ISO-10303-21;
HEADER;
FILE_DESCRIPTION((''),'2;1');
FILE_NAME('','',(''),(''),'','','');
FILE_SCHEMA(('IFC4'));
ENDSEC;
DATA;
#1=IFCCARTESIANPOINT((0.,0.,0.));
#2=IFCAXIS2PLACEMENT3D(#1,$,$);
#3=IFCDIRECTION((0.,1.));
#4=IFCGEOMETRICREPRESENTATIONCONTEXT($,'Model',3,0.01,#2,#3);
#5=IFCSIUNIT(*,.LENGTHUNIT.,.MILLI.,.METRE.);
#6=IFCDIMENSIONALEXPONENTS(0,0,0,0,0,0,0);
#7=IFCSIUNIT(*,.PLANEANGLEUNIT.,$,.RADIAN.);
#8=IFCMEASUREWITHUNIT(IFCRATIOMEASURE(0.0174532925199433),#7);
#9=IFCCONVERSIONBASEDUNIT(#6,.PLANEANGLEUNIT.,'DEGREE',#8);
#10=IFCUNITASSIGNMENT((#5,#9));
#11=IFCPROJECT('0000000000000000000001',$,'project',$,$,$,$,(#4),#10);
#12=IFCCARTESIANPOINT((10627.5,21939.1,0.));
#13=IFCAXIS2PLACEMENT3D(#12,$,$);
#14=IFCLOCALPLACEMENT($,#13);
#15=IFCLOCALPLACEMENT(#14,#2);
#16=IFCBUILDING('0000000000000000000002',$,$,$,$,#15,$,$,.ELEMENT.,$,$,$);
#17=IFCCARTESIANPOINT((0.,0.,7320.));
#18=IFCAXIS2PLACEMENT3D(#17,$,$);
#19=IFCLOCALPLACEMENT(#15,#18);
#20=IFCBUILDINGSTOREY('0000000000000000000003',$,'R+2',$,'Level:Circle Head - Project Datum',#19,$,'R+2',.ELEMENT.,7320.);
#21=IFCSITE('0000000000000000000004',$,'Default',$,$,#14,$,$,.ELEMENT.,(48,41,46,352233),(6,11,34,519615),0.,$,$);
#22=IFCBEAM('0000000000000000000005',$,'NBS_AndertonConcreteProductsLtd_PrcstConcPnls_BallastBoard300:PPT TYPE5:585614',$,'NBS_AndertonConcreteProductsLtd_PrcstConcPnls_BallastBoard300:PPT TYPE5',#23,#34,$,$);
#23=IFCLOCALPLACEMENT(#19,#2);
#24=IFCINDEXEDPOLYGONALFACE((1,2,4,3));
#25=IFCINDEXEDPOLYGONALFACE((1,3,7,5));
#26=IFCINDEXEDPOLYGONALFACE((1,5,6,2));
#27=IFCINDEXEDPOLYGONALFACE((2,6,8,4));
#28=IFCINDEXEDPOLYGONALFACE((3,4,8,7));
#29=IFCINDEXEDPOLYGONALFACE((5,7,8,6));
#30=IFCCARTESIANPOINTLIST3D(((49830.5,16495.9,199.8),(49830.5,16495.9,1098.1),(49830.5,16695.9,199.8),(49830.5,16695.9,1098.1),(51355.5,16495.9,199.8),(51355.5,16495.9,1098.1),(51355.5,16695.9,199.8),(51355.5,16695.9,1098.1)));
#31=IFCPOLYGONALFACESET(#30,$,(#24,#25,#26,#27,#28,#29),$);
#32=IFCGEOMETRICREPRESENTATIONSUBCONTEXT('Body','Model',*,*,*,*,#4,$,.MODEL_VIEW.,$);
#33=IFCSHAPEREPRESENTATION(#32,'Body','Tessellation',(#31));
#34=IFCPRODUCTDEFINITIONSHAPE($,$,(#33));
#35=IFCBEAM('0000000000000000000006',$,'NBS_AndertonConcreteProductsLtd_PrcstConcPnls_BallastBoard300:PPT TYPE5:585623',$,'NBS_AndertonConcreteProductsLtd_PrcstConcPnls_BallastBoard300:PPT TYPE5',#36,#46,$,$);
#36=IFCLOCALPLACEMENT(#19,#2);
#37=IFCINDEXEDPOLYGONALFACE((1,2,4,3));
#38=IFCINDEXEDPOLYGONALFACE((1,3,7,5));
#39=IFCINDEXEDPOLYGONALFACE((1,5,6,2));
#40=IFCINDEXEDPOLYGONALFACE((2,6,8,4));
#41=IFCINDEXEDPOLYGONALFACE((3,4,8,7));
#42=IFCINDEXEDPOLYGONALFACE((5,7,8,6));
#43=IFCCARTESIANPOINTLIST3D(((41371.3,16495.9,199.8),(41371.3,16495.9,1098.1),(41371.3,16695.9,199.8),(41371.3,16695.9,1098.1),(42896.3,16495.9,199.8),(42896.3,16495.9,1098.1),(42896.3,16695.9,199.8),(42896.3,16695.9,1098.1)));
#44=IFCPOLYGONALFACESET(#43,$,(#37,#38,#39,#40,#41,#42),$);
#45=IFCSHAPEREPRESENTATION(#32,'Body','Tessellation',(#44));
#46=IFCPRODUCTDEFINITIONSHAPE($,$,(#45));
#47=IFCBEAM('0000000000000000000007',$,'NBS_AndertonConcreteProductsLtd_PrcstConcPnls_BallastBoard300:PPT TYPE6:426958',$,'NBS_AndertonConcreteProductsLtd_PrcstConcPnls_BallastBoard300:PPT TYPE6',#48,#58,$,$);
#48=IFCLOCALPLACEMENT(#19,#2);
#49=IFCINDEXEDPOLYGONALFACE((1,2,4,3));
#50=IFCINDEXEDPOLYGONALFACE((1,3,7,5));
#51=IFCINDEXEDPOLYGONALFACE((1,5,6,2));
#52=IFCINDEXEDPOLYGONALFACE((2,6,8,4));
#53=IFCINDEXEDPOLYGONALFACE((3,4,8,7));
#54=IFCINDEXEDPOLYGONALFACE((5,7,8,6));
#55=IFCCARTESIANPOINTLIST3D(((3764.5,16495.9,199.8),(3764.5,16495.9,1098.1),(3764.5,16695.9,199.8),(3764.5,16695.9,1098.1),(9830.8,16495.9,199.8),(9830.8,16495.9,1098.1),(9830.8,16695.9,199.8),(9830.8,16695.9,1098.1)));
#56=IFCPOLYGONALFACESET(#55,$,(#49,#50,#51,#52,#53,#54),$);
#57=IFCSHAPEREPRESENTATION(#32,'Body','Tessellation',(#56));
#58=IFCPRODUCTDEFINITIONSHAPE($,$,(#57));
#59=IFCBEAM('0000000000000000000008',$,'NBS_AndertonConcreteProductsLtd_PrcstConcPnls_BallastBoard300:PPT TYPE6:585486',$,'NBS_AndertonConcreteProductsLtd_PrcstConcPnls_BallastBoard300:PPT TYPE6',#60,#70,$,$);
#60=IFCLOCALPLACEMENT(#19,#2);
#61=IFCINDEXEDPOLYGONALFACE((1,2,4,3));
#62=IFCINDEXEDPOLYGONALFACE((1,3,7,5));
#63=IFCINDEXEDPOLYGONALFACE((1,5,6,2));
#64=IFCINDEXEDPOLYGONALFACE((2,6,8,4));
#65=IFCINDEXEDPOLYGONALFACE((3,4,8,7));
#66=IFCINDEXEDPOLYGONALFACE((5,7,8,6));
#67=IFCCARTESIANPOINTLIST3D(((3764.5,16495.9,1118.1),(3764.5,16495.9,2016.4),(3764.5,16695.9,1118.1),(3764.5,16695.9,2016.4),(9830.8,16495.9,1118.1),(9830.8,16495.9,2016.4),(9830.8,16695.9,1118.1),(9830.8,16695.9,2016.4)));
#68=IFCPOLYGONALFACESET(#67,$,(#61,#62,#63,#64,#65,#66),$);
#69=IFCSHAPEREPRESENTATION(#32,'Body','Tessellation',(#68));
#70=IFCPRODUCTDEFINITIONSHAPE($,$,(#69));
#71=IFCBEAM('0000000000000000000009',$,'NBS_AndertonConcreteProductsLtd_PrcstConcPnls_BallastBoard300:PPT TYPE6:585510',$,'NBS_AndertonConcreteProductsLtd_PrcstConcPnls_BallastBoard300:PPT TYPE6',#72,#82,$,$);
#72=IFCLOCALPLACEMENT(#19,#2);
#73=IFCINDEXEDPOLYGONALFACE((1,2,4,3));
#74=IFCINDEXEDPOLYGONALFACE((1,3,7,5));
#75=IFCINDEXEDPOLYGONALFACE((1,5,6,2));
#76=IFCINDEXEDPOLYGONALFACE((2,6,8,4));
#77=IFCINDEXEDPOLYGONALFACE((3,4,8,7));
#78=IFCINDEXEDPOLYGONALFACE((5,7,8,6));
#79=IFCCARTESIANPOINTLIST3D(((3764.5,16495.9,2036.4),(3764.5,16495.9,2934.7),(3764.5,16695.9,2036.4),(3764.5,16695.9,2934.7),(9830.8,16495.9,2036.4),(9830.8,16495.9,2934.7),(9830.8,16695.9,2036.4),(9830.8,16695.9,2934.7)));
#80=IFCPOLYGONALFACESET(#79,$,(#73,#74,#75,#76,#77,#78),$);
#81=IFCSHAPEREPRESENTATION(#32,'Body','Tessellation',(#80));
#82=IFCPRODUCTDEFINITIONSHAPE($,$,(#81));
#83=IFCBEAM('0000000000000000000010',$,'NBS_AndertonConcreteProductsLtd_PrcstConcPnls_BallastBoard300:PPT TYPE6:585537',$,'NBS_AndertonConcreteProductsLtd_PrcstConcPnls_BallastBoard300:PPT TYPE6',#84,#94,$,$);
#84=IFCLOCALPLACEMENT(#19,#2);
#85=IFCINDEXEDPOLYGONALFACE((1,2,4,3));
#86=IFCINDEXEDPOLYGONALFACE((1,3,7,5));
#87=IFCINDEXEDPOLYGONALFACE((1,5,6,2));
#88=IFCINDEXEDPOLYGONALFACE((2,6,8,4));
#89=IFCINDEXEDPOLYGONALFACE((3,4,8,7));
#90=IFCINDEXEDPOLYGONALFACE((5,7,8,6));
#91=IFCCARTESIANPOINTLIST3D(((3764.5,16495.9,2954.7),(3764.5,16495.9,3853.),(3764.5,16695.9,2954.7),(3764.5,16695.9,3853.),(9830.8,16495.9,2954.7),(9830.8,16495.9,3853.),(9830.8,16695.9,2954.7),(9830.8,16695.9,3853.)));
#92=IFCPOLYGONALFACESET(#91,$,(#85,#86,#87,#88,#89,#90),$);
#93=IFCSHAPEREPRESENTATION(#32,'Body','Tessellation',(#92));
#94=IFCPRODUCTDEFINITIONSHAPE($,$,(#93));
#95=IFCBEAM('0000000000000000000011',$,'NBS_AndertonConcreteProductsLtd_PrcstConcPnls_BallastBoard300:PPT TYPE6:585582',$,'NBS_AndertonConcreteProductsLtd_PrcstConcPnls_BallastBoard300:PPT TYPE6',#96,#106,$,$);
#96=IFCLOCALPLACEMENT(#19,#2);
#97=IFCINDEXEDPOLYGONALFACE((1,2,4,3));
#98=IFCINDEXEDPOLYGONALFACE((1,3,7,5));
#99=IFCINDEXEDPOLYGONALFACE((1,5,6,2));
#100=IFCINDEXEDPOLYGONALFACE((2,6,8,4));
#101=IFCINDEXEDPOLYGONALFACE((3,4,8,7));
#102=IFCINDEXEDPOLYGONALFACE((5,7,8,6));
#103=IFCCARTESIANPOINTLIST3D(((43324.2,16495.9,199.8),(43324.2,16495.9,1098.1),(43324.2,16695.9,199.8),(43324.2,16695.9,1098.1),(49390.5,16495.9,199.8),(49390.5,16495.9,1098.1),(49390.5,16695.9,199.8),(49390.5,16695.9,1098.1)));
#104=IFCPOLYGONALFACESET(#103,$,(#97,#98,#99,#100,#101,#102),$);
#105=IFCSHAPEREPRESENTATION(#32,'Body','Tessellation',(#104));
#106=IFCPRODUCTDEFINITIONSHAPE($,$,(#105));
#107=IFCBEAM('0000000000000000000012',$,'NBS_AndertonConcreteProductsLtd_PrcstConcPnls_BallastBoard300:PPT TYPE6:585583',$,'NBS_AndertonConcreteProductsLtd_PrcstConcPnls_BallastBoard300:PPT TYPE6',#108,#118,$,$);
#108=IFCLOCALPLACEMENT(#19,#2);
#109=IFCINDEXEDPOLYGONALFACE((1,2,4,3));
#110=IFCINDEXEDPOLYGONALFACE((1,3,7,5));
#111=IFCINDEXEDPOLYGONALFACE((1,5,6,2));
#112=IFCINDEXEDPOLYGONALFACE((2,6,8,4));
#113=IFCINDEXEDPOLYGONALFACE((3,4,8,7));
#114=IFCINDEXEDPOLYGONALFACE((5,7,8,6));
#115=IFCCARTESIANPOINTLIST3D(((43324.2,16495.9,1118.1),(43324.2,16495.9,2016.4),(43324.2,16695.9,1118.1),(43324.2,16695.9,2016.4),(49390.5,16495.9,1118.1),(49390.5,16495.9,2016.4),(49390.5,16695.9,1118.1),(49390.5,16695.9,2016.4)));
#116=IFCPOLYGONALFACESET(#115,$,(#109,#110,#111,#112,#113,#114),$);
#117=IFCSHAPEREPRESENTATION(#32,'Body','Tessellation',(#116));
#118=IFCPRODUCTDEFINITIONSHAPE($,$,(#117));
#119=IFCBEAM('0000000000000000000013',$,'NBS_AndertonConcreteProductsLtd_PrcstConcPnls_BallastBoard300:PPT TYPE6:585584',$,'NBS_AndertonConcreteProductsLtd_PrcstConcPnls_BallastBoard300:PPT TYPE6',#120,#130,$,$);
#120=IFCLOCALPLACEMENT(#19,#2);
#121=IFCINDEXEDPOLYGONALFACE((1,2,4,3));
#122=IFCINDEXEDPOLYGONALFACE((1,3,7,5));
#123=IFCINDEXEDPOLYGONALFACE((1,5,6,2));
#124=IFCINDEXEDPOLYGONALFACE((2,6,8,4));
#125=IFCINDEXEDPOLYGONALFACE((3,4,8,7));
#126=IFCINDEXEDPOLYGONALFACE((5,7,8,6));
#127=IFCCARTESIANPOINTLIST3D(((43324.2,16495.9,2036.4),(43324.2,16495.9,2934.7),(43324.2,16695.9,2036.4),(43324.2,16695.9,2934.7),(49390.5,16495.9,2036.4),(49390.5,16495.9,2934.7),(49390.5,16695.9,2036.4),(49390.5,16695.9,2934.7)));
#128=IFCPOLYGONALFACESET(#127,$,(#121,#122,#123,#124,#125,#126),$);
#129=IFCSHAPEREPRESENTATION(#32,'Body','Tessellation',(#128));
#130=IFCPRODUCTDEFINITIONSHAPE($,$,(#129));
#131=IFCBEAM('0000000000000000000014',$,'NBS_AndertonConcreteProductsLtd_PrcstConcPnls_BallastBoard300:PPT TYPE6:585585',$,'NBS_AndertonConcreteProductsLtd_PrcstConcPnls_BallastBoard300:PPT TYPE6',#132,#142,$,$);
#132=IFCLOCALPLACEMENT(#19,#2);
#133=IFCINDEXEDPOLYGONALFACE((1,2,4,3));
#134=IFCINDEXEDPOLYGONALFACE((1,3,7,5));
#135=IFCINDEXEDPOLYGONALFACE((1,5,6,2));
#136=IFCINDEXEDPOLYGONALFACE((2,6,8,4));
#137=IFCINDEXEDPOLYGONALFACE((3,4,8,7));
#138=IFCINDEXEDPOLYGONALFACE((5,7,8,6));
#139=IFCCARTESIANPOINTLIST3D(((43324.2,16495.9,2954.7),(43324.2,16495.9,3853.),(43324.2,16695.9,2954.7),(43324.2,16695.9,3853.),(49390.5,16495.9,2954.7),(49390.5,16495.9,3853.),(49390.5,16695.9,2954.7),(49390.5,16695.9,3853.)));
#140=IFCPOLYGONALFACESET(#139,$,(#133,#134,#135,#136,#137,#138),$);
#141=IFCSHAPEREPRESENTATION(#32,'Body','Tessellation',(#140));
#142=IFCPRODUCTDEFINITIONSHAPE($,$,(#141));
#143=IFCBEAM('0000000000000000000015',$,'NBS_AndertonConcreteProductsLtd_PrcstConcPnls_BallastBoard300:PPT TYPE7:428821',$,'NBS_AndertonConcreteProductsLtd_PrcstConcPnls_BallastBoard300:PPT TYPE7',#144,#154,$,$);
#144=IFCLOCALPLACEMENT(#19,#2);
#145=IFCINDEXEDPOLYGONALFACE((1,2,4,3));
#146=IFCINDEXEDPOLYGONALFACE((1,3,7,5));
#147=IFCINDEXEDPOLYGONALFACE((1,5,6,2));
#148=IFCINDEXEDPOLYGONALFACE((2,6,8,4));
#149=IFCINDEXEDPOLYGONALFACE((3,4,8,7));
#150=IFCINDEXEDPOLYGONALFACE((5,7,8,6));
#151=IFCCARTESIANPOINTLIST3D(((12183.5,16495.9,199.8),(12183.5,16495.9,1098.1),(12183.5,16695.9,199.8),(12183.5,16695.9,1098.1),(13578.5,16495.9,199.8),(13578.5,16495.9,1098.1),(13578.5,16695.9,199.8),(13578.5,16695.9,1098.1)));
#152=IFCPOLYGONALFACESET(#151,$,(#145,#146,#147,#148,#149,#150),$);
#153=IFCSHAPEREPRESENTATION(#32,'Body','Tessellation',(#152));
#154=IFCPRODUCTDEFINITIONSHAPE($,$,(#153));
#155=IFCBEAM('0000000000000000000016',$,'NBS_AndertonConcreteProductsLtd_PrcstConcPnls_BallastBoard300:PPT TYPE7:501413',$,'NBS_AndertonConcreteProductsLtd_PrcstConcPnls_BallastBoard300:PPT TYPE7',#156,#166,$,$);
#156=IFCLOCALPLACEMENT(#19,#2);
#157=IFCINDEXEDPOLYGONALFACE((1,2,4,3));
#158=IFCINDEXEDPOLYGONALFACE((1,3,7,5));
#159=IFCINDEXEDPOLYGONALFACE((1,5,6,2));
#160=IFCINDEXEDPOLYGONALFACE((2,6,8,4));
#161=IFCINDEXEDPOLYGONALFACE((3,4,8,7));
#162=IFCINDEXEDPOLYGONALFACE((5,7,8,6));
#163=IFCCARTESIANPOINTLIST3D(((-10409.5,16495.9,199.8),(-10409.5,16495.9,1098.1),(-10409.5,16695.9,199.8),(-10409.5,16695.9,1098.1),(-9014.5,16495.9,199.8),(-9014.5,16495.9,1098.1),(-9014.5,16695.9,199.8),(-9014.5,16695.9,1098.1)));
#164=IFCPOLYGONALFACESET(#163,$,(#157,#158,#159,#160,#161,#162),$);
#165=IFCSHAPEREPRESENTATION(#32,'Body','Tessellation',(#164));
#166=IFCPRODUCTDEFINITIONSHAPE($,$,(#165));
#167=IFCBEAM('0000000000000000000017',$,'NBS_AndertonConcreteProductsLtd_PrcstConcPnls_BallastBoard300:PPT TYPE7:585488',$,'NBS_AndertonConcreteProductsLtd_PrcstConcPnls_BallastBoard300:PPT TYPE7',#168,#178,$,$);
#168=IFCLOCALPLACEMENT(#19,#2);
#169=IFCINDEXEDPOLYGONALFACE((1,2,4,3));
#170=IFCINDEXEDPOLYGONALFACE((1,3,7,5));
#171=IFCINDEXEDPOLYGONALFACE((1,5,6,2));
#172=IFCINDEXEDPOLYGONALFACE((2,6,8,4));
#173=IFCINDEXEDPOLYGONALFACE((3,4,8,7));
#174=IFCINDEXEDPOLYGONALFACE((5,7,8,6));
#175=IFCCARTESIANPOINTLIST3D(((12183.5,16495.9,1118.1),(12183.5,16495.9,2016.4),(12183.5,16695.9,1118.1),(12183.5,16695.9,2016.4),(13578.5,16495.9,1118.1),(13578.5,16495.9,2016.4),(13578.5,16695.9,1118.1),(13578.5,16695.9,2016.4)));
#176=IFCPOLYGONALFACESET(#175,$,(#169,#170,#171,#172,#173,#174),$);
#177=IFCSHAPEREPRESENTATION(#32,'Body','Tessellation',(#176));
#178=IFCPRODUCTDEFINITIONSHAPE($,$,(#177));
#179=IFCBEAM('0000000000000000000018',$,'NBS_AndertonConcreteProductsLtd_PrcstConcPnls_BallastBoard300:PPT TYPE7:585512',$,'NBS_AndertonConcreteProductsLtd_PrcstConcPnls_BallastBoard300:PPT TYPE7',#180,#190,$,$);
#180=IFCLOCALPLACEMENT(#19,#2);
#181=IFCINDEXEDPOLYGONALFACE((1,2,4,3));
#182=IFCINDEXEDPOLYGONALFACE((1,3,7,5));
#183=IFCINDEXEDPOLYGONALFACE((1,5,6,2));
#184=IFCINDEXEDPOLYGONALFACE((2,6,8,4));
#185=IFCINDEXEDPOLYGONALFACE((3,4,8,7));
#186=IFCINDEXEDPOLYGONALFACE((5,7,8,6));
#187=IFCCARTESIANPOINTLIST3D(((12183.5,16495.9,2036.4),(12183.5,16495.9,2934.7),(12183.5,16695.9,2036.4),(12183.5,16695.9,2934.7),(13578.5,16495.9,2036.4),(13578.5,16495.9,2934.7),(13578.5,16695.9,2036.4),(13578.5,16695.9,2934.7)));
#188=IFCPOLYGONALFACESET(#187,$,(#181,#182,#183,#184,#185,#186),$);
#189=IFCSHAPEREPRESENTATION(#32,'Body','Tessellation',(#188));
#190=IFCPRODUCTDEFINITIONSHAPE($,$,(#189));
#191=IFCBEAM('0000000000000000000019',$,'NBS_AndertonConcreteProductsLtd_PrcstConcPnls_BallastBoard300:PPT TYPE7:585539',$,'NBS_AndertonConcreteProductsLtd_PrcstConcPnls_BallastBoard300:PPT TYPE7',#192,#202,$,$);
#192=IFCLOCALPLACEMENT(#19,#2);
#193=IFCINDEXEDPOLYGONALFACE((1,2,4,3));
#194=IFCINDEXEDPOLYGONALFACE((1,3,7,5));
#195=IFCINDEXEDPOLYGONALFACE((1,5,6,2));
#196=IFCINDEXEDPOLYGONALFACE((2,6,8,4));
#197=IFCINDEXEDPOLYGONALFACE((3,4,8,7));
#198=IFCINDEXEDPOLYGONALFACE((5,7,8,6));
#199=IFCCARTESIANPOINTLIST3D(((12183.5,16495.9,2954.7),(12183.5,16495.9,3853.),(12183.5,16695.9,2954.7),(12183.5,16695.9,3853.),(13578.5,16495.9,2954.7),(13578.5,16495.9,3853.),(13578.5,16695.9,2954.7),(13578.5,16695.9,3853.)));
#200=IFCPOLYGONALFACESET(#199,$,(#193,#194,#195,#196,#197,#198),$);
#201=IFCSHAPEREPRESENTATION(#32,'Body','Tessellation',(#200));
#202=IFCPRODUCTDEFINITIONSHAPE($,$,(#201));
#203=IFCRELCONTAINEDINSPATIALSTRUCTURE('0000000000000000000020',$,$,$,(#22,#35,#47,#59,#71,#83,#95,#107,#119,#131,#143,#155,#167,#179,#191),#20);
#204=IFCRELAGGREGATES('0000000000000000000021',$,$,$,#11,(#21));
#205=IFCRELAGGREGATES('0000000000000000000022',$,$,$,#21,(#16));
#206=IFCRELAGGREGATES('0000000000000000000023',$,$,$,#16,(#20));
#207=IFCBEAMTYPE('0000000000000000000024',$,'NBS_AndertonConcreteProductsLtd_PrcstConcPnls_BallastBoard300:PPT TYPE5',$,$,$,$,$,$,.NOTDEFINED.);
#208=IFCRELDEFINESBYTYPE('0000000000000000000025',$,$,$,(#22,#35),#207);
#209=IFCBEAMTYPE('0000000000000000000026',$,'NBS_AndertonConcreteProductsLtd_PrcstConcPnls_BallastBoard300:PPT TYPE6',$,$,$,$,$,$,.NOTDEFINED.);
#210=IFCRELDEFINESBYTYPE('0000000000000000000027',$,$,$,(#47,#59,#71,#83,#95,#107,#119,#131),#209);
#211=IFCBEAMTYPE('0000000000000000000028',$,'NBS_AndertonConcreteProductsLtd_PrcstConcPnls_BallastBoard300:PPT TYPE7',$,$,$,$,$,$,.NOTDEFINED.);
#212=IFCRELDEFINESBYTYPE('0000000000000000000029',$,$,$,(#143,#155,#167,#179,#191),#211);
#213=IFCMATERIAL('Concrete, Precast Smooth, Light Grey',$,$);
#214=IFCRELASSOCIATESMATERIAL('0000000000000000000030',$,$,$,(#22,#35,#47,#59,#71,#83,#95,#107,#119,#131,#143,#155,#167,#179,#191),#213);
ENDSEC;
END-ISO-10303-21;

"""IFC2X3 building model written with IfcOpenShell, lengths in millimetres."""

from ifc_helpers import new_model, entity, si_unit, converted_unit, direction, frame, frame_2d, origin, place, context, subcontext, project, spatial, rectangle, extrude, material, type_object, element, save


model = new_model("IFC2X3")

# Units and contexts
model_context = context("Model", 3, precision=0.01, world=origin(), true_north=direction((0.0, 1.0)))
body_context = subcontext(model_context, "Body", "Model", "MODEL_VIEW")
ifc_project = project(units=[si_unit("LENGTHUNIT", "METRE", prefix="MILLI"), converted_unit("PLANEANGLEUNIT", "DEGREE", entity("IfcRatioMeasure", 0.0174532925199433), si_unit("PLANEANGLEUNIT", "RADIAN"), dimensions=[0, 0, 0, 0, 0, 0, 0])], contexts=[model_context])

# Site, building, storey
site_placement = place(None, frame((10627.5, 21939.1, 0.0)))
site = spatial("IfcSite", under=ifc_project, at=site_placement, Name="Default", CompositionType="ELEMENT", RefLatitude=(48, 41, 46, 352233), RefLongitude=(6, 11, 34, 519615), RefElevation=0.0)
building_placement = place(site_placement, origin())
building = spatial("IfcBuilding", under=site, at=building_placement, CompositionType="ELEMENT")
storey_placement = place(building_placement, frame((0.0, 0.0, 7320.0)))
storey = spatial("IfcBuildingStorey", under=building, at=storey_placement, Name="R+2", ObjectType="Level:Circle Head - Project Datum", LongName="R+2", CompositionType="ELEMENT", Elevation=7320.0)

# Shared definitions
ifc_material = material(Name="Concrete, Precast Smooth, Light Grey")

# Beams
beam_type_1 = type_object("IfcBeamType", Name="NBS_AndertonConcreteProductsLtd_PrcstConcPnls_BallastBoard300:PPT TYPE5", PredefinedType="NOTDEFINED")
beam_1_placement = place(storey_placement, origin())
element("IfcBeam", 1, at=beam_1_placement, inside=storey, type_object=beam_type_1, material=ifc_material, Name="NBS_AndertonConcreteProductsLtd_PrcstConcPnls_BallastBoard300:PPT TYPE5:585614", ObjectType="NBS_AndertonConcreteProductsLtd_PrcstConcPnls_BallastBoard300:PPT TYPE5", context=body_context, shape_type="SweptSolid", body=[
    extrude(rectangle(XDim=898.3, YDim=200.0, at=frame_2d((0.0, 0.0), x_axis=(1.0, 0.0))), frame((49830.5, 16595.9, 649.0), z_axis=(1.0, 0.0, 0.0), x_axis=(0.0, 0.0, -1.0)), (0.0, 0.0, 1.0), 1525.0),
])
beam_2_placement = place(storey_placement, origin())
element("IfcBeam", 2, at=beam_2_placement, inside=storey, type_object=beam_type_1, material=ifc_material, Name="NBS_AndertonConcreteProductsLtd_PrcstConcPnls_BallastBoard300:PPT TYPE5:585623", ObjectType="NBS_AndertonConcreteProductsLtd_PrcstConcPnls_BallastBoard300:PPT TYPE5", context=body_context, shape_type="SweptSolid", body=[
    extrude(rectangle(XDim=898.3, YDim=200.0, at=frame_2d((0.0, 0.0), x_axis=(1.0, 0.0))), frame((41371.3, 16595.9, 649.0), z_axis=(1.0, 0.0, 0.0), x_axis=(0.0, 0.0, -1.0)), (0.0, 0.0, 1.0), 1525.0),
])
beam_type_2 = type_object("IfcBeamType", Name="NBS_AndertonConcreteProductsLtd_PrcstConcPnls_BallastBoard300:PPT TYPE6", PredefinedType="NOTDEFINED")
beam_3_placement = place(storey_placement, origin())
element("IfcBeam", 3, at=beam_3_placement, inside=storey, type_object=beam_type_2, material=ifc_material, Name="NBS_AndertonConcreteProductsLtd_PrcstConcPnls_BallastBoard300:PPT TYPE6:426958", ObjectType="NBS_AndertonConcreteProductsLtd_PrcstConcPnls_BallastBoard300:PPT TYPE6", context=body_context, shape_type="SweptSolid", body=[
    extrude(rectangle(XDim=898.3, YDim=200.0, at=frame_2d((0.0, 0.0), x_axis=(0.0, 1.0))), frame((3764.5, 16595.9, 649.0), z_axis=(1.0, 0.0, 0.0), x_axis=(0.0, 1.0, 0.0)), (0.0, 0.0, 1.0), 6066.3),
])
beam_4_placement = place(storey_placement, origin())
element("IfcBeam", 4, at=beam_4_placement, inside=storey, type_object=beam_type_2, material=ifc_material, Name="NBS_AndertonConcreteProductsLtd_PrcstConcPnls_BallastBoard300:PPT TYPE6:585486", ObjectType="NBS_AndertonConcreteProductsLtd_PrcstConcPnls_BallastBoard300:PPT TYPE6", context=body_context, shape_type="SweptSolid", body=[
    extrude(rectangle(XDim=898.3, YDim=200.0, at=frame_2d((0.0, 0.0), x_axis=(0.0, 1.0))), frame((3764.5, 16595.9, 1567.3), z_axis=(1.0, 0.0, 0.0), x_axis=(0.0, 1.0, 0.0)), (0.0, 0.0, 1.0), 6066.3),
])
beam_5_placement = place(storey_placement, origin())
element("IfcBeam", 5, at=beam_5_placement, inside=storey, type_object=beam_type_2, material=ifc_material, Name="NBS_AndertonConcreteProductsLtd_PrcstConcPnls_BallastBoard300:PPT TYPE6:585510", ObjectType="NBS_AndertonConcreteProductsLtd_PrcstConcPnls_BallastBoard300:PPT TYPE6", context=body_context, shape_type="SweptSolid", body=[
    extrude(rectangle(XDim=898.3, YDim=200.0, at=frame_2d((0.0, 0.0), x_axis=(0.0, 1.0))), frame((3764.5, 16595.9, 2485.6), z_axis=(1.0, 0.0, 0.0), x_axis=(0.0, 1.0, 0.0)), (0.0, 0.0, 1.0), 6066.3),
])
beam_6_placement = place(storey_placement, origin())
element("IfcBeam", 6, at=beam_6_placement, inside=storey, type_object=beam_type_2, material=ifc_material, Name="NBS_AndertonConcreteProductsLtd_PrcstConcPnls_BallastBoard300:PPT TYPE6:585537", ObjectType="NBS_AndertonConcreteProductsLtd_PrcstConcPnls_BallastBoard300:PPT TYPE6", context=body_context, shape_type="SweptSolid", body=[
    extrude(rectangle(XDim=898.3, YDim=200.0, at=frame_2d((0.0, 0.0), x_axis=(0.0, 1.0))), frame((3764.5, 16595.9, 3403.9), z_axis=(1.0, 0.0, 0.0), x_axis=(0.0, 1.0, 0.0)), (0.0, 0.0, 1.0), 6066.3),
])
beam_7_placement = place(storey_placement, origin())
element("IfcBeam", 7, at=beam_7_placement, inside=storey, type_object=beam_type_2, material=ifc_material, Name="NBS_AndertonConcreteProductsLtd_PrcstConcPnls_BallastBoard300:PPT TYPE6:585582", ObjectType="NBS_AndertonConcreteProductsLtd_PrcstConcPnls_BallastBoard300:PPT TYPE6", context=body_context, shape_type="SweptSolid", body=[
    extrude(rectangle(XDim=898.3, YDim=200.0, at=frame_2d((0.0, 0.0), x_axis=(1.0, 0.0))), frame((43324.2, 16595.9, 649.0), z_axis=(1.0, 0.0, 0.0), x_axis=(0.0, 0.0, -1.0)), (0.0, 0.0, 1.0), 6066.3),
])
beam_8_placement = place(storey_placement, origin())
element("IfcBeam", 8, at=beam_8_placement, inside=storey, type_object=beam_type_2, material=ifc_material, Name="NBS_AndertonConcreteProductsLtd_PrcstConcPnls_BallastBoard300:PPT TYPE6:585583", ObjectType="NBS_AndertonConcreteProductsLtd_PrcstConcPnls_BallastBoard300:PPT TYPE6", context=body_context, shape_type="SweptSolid", body=[
    extrude(rectangle(XDim=898.3, YDim=200.0, at=frame_2d((0.0, 0.0), x_axis=(1.0, 0.0))), frame((43324.2, 16595.9, 1567.3), z_axis=(1.0, 0.0, 0.0), x_axis=(0.0, 0.0, -1.0)), (0.0, 0.0, 1.0), 6066.3),
])
beam_9_placement = place(storey_placement, origin())
element("IfcBeam", 9, at=beam_9_placement, inside=storey, type_object=beam_type_2, material=ifc_material, Name="NBS_AndertonConcreteProductsLtd_PrcstConcPnls_BallastBoard300:PPT TYPE6:585584", ObjectType="NBS_AndertonConcreteProductsLtd_PrcstConcPnls_BallastBoard300:PPT TYPE6", context=body_context, shape_type="SweptSolid", body=[
    extrude(rectangle(XDim=898.3, YDim=200.0, at=frame_2d((0.0, 0.0), x_axis=(1.0, 0.0))), frame((43324.2, 16595.9, 2485.6), z_axis=(1.0, 0.0, 0.0), x_axis=(0.0, 0.0, -1.0)), (0.0, 0.0, 1.0), 6066.3),
])
beam_10_placement = place(storey_placement, origin())
element("IfcBeam", 10, at=beam_10_placement, inside=storey, type_object=beam_type_2, material=ifc_material, Name="NBS_AndertonConcreteProductsLtd_PrcstConcPnls_BallastBoard300:PPT TYPE6:585585", ObjectType="NBS_AndertonConcreteProductsLtd_PrcstConcPnls_BallastBoard300:PPT TYPE6", context=body_context, shape_type="SweptSolid", body=[
    extrude(rectangle(XDim=898.3, YDim=200.0, at=frame_2d((0.0, 0.0), x_axis=(1.0, 0.0))), frame((43324.2, 16595.9, 3403.9), z_axis=(1.0, 0.0, 0.0), x_axis=(0.0, 0.0, -1.0)), (0.0, 0.0, 1.0), 6066.3),
])
beam_type_3 = type_object("IfcBeamType", Name="NBS_AndertonConcreteProductsLtd_PrcstConcPnls_BallastBoard300:PPT TYPE7", PredefinedType="NOTDEFINED")
beam_11_placement = place(storey_placement, origin())
element("IfcBeam", 11, at=beam_11_placement, inside=storey, type_object=beam_type_3, material=ifc_material, Name="NBS_AndertonConcreteProductsLtd_PrcstConcPnls_BallastBoard300:PPT TYPE7:428821", ObjectType="NBS_AndertonConcreteProductsLtd_PrcstConcPnls_BallastBoard300:PPT TYPE7", context=body_context, shape_type="SweptSolid", body=[
    extrude(rectangle(XDim=898.3, YDim=200.0, at=frame_2d((0.0, 0.0), x_axis=(0.0, 1.0))), frame((12183.5, 16595.9, 649.0), z_axis=(1.0, 0.0, 0.0), x_axis=(0.0, 1.0, 0.0)), (0.0, 0.0, 1.0), 1395.0),
])
beam_12_placement = place(storey_placement, origin())
element("IfcBeam", 12, at=beam_12_placement, inside=storey, type_object=beam_type_3, material=ifc_material, Name="NBS_AndertonConcreteProductsLtd_PrcstConcPnls_BallastBoard300:PPT TYPE7:501413", ObjectType="NBS_AndertonConcreteProductsLtd_PrcstConcPnls_BallastBoard300:PPT TYPE7", context=body_context, shape_type="SweptSolid", body=[
    extrude(rectangle(XDim=898.3, YDim=200.0, at=frame_2d((0.0, 0.0), x_axis=(0.0, 1.0))), frame((-10409.5, 16595.9, 649.0), z_axis=(1.0, 0.0, 0.0), x_axis=(0.0, 1.0, 0.0)), (0.0, 0.0, 1.0), 1395.0),
])
beam_13_placement = place(storey_placement, origin())
element("IfcBeam", 13, at=beam_13_placement, inside=storey, type_object=beam_type_3, material=ifc_material, Name="NBS_AndertonConcreteProductsLtd_PrcstConcPnls_BallastBoard300:PPT TYPE7:585488", ObjectType="NBS_AndertonConcreteProductsLtd_PrcstConcPnls_BallastBoard300:PPT TYPE7", context=body_context, shape_type="SweptSolid", body=[
    extrude(rectangle(XDim=898.3, YDim=200.0, at=frame_2d((0.0, 0.0), x_axis=(0.0, 1.0))), frame((12183.5, 16595.9, 1567.3), z_axis=(1.0, 0.0, 0.0), x_axis=(0.0, 1.0, 0.0)), (0.0, 0.0, 1.0), 1395.0),
])
beam_14_placement = place(storey_placement, origin())
element("IfcBeam", 14, at=beam_14_placement, inside=storey, type_object=beam_type_3, material=ifc_material, Name="NBS_AndertonConcreteProductsLtd_PrcstConcPnls_BallastBoard300:PPT TYPE7:585512", ObjectType="NBS_AndertonConcreteProductsLtd_PrcstConcPnls_BallastBoard300:PPT TYPE7", context=body_context, shape_type="SweptSolid", body=[
    extrude(rectangle(XDim=898.3, YDim=200.0, at=frame_2d((0.0, 0.0), x_axis=(0.0, 1.0))), frame((12183.5, 16595.9, 2485.6), z_axis=(1.0, 0.0, 0.0), x_axis=(0.0, 1.0, 0.0)), (0.0, 0.0, 1.0), 1395.0),
])
beam_15_placement = place(storey_placement, origin())
element("IfcBeam", 15, at=beam_15_placement, inside=storey, type_object=beam_type_3, material=ifc_material, Name="NBS_AndertonConcreteProductsLtd_PrcstConcPnls_BallastBoard300:PPT TYPE7:585539", ObjectType="NBS_AndertonConcreteProductsLtd_PrcstConcPnls_BallastBoard300:PPT TYPE7", context=body_context, shape_type="SweptSolid", body=[
    extrude(rectangle(XDim=898.3, YDim=200.0, at=frame_2d((0.0, 0.0), x_axis=(0.0, 1.0))), frame((12183.5, 16595.9, 3403.9), z_axis=(1.0, 0.0, 0.0), x_axis=(0.0, 1.0, 0.0)), (0.0, 0.0, 1.0), 1395.0),
])

save(model, "model.ifc")
